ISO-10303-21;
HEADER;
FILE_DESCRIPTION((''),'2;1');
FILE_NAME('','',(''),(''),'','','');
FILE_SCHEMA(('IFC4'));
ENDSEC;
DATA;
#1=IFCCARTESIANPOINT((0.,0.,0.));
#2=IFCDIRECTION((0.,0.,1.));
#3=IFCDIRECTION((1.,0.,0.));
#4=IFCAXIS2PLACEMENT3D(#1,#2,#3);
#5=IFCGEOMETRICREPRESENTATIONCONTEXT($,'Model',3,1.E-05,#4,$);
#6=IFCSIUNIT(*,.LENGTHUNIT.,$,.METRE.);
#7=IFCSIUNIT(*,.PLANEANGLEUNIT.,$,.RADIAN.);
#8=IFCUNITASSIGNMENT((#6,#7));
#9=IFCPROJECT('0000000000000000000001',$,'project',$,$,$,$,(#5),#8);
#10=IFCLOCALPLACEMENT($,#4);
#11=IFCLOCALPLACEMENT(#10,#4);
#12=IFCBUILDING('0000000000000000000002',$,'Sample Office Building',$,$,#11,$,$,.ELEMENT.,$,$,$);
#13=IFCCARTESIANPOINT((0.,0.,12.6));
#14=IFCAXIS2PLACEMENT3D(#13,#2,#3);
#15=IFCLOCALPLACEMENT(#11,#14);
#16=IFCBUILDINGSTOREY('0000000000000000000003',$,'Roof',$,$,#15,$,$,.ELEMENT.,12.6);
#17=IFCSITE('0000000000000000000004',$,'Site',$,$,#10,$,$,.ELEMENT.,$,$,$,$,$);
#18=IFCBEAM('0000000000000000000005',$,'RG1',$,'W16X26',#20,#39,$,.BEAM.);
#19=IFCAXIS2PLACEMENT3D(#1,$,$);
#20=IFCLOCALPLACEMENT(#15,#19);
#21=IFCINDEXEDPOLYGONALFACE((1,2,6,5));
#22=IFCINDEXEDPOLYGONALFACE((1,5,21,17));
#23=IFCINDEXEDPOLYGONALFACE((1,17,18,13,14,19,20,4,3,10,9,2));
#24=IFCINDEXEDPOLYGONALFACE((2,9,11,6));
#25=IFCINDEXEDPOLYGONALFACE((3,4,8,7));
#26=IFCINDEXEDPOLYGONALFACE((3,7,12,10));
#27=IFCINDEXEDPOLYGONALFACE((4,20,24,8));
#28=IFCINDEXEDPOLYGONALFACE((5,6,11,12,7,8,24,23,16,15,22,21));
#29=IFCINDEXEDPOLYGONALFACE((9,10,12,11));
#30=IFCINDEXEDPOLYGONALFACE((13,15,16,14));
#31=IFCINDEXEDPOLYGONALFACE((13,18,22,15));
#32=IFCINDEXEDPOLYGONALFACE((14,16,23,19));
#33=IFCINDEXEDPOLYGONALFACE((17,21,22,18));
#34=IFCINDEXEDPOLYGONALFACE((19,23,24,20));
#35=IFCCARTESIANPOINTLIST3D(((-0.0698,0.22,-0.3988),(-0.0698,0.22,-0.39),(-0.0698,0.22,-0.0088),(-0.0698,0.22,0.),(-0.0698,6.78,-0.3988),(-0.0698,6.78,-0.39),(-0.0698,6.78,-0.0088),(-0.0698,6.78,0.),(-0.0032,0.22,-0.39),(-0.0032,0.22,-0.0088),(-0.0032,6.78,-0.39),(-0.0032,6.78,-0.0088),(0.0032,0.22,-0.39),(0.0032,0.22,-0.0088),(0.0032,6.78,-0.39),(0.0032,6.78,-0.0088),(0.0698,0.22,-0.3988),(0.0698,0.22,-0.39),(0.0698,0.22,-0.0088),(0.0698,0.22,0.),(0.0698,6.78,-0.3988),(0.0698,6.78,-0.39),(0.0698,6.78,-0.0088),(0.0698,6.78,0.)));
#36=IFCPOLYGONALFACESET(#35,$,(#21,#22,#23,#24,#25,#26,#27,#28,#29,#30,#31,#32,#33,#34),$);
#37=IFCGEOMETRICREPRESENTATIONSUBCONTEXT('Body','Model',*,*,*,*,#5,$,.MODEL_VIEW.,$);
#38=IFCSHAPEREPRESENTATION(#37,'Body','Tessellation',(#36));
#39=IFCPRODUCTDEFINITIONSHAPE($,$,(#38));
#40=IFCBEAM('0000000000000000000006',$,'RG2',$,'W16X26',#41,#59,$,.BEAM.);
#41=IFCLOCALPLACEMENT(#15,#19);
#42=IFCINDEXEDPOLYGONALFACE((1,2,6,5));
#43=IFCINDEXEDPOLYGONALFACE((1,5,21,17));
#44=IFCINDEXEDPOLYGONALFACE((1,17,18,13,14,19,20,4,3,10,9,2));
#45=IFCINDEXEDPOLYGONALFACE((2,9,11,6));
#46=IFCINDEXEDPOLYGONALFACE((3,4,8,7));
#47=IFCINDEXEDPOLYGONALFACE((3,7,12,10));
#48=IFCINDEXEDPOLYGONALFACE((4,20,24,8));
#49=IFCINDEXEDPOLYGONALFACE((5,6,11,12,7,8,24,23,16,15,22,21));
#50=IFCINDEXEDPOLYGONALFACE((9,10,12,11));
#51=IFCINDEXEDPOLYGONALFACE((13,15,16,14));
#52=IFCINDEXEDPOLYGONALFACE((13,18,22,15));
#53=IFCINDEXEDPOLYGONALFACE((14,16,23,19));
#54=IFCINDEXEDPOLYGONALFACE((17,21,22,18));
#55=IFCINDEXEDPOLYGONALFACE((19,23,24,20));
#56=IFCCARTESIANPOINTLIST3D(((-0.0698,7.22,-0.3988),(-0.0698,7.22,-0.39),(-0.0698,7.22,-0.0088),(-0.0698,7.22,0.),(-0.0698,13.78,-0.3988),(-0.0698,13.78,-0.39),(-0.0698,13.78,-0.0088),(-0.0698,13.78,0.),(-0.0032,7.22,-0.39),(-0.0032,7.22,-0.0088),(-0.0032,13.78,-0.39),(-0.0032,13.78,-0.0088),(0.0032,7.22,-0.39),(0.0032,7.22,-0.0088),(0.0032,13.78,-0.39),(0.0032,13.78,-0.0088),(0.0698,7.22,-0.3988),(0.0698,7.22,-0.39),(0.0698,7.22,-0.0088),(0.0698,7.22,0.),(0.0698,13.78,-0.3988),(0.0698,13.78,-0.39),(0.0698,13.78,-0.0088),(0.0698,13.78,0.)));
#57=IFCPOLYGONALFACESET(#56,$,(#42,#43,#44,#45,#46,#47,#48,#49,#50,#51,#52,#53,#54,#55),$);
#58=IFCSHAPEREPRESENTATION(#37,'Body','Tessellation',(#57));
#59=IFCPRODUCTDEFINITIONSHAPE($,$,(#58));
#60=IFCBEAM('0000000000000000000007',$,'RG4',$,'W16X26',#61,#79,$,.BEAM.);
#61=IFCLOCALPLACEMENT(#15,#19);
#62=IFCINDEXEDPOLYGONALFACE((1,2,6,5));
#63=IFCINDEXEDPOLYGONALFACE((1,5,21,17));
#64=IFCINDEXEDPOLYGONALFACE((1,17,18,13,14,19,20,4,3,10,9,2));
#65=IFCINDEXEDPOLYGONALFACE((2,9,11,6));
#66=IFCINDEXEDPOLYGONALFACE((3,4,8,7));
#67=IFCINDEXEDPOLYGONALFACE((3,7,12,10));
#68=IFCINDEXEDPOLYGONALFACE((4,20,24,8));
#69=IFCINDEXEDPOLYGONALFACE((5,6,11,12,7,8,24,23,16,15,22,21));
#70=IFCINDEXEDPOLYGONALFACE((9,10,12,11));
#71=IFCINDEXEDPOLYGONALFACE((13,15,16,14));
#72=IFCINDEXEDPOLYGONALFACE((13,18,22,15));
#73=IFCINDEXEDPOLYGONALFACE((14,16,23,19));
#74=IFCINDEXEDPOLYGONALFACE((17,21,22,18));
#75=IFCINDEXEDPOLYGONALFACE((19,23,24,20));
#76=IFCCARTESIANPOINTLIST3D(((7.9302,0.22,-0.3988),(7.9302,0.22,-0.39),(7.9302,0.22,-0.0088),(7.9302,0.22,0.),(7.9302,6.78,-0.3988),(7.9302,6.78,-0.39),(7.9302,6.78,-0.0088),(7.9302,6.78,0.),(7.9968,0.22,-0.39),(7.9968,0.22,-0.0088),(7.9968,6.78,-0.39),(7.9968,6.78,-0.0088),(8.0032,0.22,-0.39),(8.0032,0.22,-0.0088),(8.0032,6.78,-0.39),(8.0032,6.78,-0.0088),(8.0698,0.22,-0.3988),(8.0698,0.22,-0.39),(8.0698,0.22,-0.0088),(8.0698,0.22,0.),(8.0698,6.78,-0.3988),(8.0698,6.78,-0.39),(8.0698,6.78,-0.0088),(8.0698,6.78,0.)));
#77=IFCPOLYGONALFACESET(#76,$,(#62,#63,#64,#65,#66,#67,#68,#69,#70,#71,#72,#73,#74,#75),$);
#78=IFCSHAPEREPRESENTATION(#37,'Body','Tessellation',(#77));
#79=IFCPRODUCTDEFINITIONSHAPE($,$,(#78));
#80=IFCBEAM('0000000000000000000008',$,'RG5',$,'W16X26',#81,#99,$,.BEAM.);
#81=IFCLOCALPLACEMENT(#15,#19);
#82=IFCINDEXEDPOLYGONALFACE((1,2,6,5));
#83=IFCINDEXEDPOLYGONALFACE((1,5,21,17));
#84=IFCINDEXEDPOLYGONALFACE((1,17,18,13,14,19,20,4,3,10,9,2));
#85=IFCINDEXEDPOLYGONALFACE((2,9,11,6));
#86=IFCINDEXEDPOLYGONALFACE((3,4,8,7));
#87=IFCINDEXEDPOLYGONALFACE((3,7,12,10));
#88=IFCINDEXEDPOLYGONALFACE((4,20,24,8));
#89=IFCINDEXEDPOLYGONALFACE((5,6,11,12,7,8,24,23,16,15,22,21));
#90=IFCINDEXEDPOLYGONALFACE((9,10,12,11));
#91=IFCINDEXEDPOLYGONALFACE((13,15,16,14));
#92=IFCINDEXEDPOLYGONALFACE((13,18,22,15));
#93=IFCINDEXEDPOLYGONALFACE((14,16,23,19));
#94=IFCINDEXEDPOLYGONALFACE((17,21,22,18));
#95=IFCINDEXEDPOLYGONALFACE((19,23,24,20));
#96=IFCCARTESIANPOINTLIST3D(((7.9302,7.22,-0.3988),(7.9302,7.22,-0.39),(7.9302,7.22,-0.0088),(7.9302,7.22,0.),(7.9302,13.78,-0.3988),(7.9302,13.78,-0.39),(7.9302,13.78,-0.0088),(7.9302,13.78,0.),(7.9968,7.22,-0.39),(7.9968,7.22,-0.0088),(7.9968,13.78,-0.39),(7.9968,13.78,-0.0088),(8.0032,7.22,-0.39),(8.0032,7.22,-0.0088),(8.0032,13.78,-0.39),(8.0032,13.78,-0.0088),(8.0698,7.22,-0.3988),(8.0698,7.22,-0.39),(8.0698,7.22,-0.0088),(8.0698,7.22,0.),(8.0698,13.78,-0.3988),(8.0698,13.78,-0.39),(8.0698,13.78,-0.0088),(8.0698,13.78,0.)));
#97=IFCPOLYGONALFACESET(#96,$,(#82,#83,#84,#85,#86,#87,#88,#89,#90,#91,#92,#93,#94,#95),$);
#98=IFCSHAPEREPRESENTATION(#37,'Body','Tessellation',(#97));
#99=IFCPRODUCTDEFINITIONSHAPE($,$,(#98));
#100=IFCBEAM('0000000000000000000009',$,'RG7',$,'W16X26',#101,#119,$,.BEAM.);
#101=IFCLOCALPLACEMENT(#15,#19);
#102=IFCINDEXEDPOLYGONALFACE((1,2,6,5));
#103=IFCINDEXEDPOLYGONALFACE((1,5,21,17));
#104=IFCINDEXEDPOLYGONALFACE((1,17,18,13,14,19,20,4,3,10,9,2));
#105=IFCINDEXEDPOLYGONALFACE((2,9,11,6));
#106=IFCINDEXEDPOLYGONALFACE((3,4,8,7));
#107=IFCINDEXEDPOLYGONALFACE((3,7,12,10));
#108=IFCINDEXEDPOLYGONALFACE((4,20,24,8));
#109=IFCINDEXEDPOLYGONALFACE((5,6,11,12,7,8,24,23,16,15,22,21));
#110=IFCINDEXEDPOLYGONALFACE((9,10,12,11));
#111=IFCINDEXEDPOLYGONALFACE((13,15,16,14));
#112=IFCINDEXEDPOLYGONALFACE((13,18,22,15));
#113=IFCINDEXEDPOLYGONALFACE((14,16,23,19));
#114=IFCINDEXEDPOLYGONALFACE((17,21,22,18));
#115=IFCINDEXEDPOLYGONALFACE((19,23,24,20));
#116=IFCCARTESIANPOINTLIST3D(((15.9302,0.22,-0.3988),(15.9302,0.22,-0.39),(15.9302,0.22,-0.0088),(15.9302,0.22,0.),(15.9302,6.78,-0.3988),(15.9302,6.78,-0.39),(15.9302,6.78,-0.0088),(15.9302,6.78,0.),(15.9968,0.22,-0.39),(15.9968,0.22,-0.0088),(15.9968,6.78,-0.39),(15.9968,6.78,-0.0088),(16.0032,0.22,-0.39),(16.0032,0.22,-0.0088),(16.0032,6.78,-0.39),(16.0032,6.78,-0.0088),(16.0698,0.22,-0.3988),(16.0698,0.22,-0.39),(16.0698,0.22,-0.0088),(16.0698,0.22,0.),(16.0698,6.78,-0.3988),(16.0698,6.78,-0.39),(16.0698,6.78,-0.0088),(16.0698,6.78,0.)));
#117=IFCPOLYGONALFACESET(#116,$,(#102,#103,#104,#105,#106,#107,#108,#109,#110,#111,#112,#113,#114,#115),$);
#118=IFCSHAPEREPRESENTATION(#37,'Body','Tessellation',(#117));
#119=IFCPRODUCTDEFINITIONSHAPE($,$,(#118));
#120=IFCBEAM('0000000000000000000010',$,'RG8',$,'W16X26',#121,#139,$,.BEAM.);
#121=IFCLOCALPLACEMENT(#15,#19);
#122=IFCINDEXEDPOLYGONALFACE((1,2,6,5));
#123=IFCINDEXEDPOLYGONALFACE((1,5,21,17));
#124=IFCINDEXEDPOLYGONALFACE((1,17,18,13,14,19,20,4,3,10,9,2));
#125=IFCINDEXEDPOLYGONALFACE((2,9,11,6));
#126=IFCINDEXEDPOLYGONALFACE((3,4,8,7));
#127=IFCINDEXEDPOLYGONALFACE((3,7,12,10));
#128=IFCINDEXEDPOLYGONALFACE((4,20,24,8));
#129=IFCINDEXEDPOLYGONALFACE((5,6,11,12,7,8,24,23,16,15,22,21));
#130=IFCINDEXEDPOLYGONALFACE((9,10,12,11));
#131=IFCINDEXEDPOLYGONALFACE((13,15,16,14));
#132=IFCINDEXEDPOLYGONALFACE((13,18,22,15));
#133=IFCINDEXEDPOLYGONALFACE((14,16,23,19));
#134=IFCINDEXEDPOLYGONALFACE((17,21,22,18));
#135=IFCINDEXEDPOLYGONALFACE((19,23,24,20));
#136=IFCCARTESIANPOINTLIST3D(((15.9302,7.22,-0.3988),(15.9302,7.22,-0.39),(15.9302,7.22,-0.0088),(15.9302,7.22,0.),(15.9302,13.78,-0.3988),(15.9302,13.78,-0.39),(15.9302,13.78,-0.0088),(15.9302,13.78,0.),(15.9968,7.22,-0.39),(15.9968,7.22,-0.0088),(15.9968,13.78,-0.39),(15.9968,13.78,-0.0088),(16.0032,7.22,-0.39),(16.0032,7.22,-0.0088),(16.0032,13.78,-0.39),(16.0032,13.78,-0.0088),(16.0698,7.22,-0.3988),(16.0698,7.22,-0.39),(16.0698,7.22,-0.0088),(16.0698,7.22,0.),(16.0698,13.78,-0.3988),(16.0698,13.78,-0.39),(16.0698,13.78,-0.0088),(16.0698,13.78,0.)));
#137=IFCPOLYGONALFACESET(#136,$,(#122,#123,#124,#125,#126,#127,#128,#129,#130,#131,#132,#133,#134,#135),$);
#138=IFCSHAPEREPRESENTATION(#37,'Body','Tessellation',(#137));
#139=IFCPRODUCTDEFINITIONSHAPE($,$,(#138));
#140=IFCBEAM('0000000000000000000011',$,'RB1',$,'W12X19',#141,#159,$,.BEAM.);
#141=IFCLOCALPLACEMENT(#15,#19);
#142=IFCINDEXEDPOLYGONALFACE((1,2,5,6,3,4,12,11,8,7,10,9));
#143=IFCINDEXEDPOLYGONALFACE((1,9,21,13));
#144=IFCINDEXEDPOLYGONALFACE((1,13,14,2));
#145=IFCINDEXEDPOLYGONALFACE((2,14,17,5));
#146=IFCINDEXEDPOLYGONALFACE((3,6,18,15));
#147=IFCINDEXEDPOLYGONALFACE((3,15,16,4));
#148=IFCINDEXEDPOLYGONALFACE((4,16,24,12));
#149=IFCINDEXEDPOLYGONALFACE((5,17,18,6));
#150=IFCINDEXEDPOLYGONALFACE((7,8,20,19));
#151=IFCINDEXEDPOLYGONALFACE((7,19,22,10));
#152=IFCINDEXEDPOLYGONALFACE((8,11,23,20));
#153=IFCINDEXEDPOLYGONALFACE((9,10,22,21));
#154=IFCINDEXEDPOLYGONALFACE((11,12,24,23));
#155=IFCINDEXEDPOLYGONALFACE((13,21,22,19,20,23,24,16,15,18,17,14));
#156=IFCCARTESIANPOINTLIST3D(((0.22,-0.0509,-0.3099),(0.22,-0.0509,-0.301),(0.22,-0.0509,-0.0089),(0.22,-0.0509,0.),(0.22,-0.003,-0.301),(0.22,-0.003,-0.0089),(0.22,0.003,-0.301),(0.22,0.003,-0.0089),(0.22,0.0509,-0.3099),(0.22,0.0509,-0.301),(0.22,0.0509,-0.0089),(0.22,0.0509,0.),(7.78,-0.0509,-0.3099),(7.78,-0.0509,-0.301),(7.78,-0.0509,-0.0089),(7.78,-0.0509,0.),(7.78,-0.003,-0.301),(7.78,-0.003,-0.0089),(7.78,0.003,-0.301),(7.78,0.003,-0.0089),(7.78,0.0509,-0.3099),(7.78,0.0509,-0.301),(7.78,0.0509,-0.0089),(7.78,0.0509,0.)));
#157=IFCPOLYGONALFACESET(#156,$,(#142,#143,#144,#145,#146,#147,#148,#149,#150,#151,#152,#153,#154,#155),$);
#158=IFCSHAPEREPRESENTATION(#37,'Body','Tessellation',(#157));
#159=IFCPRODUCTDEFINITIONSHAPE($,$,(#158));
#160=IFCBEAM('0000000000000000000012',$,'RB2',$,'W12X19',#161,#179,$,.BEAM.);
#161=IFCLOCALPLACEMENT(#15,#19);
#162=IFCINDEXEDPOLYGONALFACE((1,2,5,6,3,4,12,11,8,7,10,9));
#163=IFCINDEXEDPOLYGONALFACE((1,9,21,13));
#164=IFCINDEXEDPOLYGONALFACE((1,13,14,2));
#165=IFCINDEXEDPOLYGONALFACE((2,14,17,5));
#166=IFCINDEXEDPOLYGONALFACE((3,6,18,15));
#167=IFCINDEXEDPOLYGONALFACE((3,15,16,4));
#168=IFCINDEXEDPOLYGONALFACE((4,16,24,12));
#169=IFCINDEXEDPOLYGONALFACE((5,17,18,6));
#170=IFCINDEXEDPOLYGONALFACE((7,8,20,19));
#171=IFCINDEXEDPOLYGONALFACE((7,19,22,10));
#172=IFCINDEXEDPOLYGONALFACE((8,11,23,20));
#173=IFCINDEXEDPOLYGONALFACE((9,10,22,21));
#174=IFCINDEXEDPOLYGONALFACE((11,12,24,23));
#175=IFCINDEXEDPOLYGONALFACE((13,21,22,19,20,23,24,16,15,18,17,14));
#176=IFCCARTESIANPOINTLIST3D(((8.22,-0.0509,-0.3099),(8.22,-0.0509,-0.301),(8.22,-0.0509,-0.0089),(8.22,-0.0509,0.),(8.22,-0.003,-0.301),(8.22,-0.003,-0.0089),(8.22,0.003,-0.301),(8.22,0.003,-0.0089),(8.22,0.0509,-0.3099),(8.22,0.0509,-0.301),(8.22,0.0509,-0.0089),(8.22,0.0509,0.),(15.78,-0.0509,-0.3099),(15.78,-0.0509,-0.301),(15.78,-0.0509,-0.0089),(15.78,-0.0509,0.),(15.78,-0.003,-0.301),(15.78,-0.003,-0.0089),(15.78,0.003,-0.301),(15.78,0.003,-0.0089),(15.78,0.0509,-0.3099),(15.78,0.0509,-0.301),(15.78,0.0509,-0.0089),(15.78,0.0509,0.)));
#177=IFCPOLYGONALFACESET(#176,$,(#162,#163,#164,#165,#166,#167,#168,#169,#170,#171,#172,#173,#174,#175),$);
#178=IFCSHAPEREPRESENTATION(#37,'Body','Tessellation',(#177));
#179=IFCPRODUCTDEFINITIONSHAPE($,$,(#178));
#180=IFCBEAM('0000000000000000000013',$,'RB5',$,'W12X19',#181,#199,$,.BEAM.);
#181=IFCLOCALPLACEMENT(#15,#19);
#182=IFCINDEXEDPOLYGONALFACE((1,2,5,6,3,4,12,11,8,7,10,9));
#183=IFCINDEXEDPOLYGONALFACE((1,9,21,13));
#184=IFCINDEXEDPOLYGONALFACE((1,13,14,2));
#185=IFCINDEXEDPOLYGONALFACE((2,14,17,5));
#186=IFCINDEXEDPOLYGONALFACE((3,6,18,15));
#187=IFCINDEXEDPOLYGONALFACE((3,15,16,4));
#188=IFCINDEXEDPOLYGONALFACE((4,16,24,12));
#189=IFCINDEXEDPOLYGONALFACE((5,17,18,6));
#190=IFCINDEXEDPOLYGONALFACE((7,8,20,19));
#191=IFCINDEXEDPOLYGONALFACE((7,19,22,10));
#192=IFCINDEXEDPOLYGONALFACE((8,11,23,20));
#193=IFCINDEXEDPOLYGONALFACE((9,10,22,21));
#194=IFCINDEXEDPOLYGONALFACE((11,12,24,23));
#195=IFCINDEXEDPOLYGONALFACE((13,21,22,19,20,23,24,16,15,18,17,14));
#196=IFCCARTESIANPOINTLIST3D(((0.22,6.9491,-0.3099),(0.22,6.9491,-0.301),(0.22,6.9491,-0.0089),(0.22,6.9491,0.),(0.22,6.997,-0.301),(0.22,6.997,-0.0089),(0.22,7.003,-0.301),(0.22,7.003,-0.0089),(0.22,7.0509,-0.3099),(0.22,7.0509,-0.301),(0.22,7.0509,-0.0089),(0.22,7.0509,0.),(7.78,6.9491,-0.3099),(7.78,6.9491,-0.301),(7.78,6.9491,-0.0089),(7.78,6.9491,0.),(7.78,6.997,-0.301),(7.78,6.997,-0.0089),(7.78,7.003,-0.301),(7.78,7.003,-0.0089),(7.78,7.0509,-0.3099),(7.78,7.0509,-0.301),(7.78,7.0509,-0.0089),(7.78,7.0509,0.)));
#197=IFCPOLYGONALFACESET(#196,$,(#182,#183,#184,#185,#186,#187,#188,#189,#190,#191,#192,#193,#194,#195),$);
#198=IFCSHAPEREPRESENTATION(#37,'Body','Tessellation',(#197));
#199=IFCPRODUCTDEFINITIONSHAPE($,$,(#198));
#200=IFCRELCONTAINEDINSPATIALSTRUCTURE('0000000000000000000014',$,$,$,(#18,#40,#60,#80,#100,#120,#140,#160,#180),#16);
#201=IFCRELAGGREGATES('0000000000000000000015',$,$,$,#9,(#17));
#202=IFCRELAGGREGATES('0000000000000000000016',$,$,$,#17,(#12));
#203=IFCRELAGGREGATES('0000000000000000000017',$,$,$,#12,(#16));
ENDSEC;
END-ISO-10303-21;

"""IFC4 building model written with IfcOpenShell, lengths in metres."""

from ifc_helpers import new_model, si_unit, frame, origin_with_axes, place, context, subcontext, project, spatial, i_section, extrude, element, save


model = new_model("IFC4")

# Units and contexts
model_context = context("Model", 3, precision=1e-05, world=origin_with_axes())
body_context = subcontext(model_context, "Body", "Model", "MODEL_VIEW")
ifc_project = project(units=[si_unit("LENGTHUNIT", "METRE"), si_unit("PLANEANGLEUNIT", "RADIAN")], contexts=[model_context])

# Site, building, storey
site_placement = place(None, origin_with_axes())
site = spatial("IfcSite", under=ifc_project, at=site_placement, Name="Site", CompositionType="ELEMENT")
building_placement = place(site_placement, origin_with_axes())
building = spatial("IfcBuilding", under=site, at=building_placement, Name="Sample Office Building", CompositionType="ELEMENT")
storey_placement = place(building_placement, frame((0.0, 0.0, 12.6), z_axis=(0.0, 0.0, 1.0), x_axis=(1.0, 0.0, 0.0)))
storey = spatial("IfcBuildingStorey", under=building, at=storey_placement, Name="Roof", CompositionType="ELEMENT", Elevation=12.6)

# Beams
beam_1_placement = place(None, frame((0.0, 0.22, 12.4006), z_axis=(0.0, 1.0, 0.0), x_axis=(-1.0, 0.0, 0.0)))
element("IfcBeam", 1, at=beam_1_placement, inside=storey, Name="RG1", ObjectType="W16X26", PredefinedType="BEAM", context=body_context, shape_type="SweptSolid", body=[
    extrude(i_section(OverallWidth=0.1397, OverallDepth=0.3988, WebThickness=0.0063, FlangeThickness=0.0088), None, (0.0, 0.0, 1.0), 6.56),
])
beam_2_placement = place(None, frame((0.0, 7.22, 12.4006), z_axis=(0.0, 1.0, 0.0), x_axis=(-1.0, 0.0, 0.0)))
element("IfcBeam", 2, at=beam_2_placement, inside=storey, Name="RG2", ObjectType="W16X26", PredefinedType="BEAM", context=body_context, shape_type="SweptSolid", body=[
    extrude(i_section(OverallWidth=0.1397, OverallDepth=0.3988, WebThickness=0.0063, FlangeThickness=0.0088), None, (0.0, 0.0, 1.0), 6.56),
])
beam_3_placement = place(None, frame((8.0, 0.22, 12.4006), z_axis=(0.0, 1.0, 0.0), x_axis=(-1.0, 0.0, 0.0)))
element("IfcBeam", 3, at=beam_3_placement, inside=storey, Name="RG4", ObjectType="W16X26", PredefinedType="BEAM", context=body_context, shape_type="SweptSolid", body=[
    extrude(i_section(OverallWidth=0.1397, OverallDepth=0.3988, WebThickness=0.0063, FlangeThickness=0.0088), None, (0.0, 0.0, 1.0), 6.56),
])
beam_4_placement = place(None, frame((8.0, 7.22, 12.4006), z_axis=(0.0, 1.0, 0.0), x_axis=(-1.0, 0.0, 0.0)))
element("IfcBeam", 4, at=beam_4_placement, inside=storey, Name="RG5", ObjectType="W16X26", PredefinedType="BEAM", context=body_context, shape_type="SweptSolid", body=[
    extrude(i_section(OverallWidth=0.1397, OverallDepth=0.3988, WebThickness=0.0063, FlangeThickness=0.0088), None, (0.0, 0.0, 1.0), 6.56),
])
beam_5_placement = place(None, frame((16.0, 0.22, 12.4006), z_axis=(0.0, 1.0, 0.0), x_axis=(-1.0, 0.0, 0.0)))
element("IfcBeam", 5, at=beam_5_placement, inside=storey, Name="RG7", ObjectType="W16X26", PredefinedType="BEAM", context=body_context, shape_type="SweptSolid", body=[
    extrude(i_section(OverallWidth=0.1397, OverallDepth=0.3988, WebThickness=0.0063, FlangeThickness=0.0088), None, (0.0, 0.0, 1.0), 6.56),
])
beam_6_placement = place(None, frame((16.0, 7.22, 12.4006), z_axis=(0.0, 1.0, 0.0), x_axis=(-1.0, 0.0, 0.0)))
element("IfcBeam", 6, at=beam_6_placement, inside=storey, Name="RG8", ObjectType="W16X26", PredefinedType="BEAM", context=body_context, shape_type="SweptSolid", body=[
    extrude(i_section(OverallWidth=0.1397, OverallDepth=0.3988, WebThickness=0.0063, FlangeThickness=0.0088), None, (0.0, 0.0, 1.0), 6.56),
])
beam_7_placement = place(None, frame((0.22, 0.0, 12.4451), z_axis=(1.0, 0.0, 0.0), x_axis=(0.0, 1.0, 0.0)))
element("IfcBeam", 7, at=beam_7_placement, inside=storey, Name="RB1", ObjectType="W12X19", PredefinedType="BEAM", context=body_context, shape_type="SweptSolid", body=[
    extrude(i_section(OverallWidth=0.1019, OverallDepth=0.3099, WebThickness=0.006, FlangeThickness=0.0089), None, (0.0, 0.0, 1.0), 7.56),
])
beam_8_placement = place(None, frame((8.22, 0.0, 12.4451), z_axis=(1.0, 0.0, 0.0), x_axis=(0.0, 1.0, 0.0)))
element("IfcBeam", 8, at=beam_8_placement, inside=storey, Name="RB2", ObjectType="W12X19", PredefinedType="BEAM", context=body_context, shape_type="SweptSolid", body=[
    extrude(i_section(OverallWidth=0.1019, OverallDepth=0.3099, WebThickness=0.006, FlangeThickness=0.0089), None, (0.0, 0.0, 1.0), 7.56),
])
beam_9_placement = place(None, frame((0.22, 7.0, 12.4451), z_axis=(1.0, 0.0, 0.0), x_axis=(0.0, 1.0, 0.0)))
element("IfcBeam", 9, at=beam_9_placement, inside=storey, Name="RB5", ObjectType="W12X19", PredefinedType="BEAM", context=body_context, shape_type="SweptSolid", body=[
    extrude(i_section(OverallWidth=0.1019, OverallDepth=0.3099, WebThickness=0.006, FlangeThickness=0.0089), None, (0.0, 0.0, 1.0), 7.56),
])

save(model, "model.ifc")
